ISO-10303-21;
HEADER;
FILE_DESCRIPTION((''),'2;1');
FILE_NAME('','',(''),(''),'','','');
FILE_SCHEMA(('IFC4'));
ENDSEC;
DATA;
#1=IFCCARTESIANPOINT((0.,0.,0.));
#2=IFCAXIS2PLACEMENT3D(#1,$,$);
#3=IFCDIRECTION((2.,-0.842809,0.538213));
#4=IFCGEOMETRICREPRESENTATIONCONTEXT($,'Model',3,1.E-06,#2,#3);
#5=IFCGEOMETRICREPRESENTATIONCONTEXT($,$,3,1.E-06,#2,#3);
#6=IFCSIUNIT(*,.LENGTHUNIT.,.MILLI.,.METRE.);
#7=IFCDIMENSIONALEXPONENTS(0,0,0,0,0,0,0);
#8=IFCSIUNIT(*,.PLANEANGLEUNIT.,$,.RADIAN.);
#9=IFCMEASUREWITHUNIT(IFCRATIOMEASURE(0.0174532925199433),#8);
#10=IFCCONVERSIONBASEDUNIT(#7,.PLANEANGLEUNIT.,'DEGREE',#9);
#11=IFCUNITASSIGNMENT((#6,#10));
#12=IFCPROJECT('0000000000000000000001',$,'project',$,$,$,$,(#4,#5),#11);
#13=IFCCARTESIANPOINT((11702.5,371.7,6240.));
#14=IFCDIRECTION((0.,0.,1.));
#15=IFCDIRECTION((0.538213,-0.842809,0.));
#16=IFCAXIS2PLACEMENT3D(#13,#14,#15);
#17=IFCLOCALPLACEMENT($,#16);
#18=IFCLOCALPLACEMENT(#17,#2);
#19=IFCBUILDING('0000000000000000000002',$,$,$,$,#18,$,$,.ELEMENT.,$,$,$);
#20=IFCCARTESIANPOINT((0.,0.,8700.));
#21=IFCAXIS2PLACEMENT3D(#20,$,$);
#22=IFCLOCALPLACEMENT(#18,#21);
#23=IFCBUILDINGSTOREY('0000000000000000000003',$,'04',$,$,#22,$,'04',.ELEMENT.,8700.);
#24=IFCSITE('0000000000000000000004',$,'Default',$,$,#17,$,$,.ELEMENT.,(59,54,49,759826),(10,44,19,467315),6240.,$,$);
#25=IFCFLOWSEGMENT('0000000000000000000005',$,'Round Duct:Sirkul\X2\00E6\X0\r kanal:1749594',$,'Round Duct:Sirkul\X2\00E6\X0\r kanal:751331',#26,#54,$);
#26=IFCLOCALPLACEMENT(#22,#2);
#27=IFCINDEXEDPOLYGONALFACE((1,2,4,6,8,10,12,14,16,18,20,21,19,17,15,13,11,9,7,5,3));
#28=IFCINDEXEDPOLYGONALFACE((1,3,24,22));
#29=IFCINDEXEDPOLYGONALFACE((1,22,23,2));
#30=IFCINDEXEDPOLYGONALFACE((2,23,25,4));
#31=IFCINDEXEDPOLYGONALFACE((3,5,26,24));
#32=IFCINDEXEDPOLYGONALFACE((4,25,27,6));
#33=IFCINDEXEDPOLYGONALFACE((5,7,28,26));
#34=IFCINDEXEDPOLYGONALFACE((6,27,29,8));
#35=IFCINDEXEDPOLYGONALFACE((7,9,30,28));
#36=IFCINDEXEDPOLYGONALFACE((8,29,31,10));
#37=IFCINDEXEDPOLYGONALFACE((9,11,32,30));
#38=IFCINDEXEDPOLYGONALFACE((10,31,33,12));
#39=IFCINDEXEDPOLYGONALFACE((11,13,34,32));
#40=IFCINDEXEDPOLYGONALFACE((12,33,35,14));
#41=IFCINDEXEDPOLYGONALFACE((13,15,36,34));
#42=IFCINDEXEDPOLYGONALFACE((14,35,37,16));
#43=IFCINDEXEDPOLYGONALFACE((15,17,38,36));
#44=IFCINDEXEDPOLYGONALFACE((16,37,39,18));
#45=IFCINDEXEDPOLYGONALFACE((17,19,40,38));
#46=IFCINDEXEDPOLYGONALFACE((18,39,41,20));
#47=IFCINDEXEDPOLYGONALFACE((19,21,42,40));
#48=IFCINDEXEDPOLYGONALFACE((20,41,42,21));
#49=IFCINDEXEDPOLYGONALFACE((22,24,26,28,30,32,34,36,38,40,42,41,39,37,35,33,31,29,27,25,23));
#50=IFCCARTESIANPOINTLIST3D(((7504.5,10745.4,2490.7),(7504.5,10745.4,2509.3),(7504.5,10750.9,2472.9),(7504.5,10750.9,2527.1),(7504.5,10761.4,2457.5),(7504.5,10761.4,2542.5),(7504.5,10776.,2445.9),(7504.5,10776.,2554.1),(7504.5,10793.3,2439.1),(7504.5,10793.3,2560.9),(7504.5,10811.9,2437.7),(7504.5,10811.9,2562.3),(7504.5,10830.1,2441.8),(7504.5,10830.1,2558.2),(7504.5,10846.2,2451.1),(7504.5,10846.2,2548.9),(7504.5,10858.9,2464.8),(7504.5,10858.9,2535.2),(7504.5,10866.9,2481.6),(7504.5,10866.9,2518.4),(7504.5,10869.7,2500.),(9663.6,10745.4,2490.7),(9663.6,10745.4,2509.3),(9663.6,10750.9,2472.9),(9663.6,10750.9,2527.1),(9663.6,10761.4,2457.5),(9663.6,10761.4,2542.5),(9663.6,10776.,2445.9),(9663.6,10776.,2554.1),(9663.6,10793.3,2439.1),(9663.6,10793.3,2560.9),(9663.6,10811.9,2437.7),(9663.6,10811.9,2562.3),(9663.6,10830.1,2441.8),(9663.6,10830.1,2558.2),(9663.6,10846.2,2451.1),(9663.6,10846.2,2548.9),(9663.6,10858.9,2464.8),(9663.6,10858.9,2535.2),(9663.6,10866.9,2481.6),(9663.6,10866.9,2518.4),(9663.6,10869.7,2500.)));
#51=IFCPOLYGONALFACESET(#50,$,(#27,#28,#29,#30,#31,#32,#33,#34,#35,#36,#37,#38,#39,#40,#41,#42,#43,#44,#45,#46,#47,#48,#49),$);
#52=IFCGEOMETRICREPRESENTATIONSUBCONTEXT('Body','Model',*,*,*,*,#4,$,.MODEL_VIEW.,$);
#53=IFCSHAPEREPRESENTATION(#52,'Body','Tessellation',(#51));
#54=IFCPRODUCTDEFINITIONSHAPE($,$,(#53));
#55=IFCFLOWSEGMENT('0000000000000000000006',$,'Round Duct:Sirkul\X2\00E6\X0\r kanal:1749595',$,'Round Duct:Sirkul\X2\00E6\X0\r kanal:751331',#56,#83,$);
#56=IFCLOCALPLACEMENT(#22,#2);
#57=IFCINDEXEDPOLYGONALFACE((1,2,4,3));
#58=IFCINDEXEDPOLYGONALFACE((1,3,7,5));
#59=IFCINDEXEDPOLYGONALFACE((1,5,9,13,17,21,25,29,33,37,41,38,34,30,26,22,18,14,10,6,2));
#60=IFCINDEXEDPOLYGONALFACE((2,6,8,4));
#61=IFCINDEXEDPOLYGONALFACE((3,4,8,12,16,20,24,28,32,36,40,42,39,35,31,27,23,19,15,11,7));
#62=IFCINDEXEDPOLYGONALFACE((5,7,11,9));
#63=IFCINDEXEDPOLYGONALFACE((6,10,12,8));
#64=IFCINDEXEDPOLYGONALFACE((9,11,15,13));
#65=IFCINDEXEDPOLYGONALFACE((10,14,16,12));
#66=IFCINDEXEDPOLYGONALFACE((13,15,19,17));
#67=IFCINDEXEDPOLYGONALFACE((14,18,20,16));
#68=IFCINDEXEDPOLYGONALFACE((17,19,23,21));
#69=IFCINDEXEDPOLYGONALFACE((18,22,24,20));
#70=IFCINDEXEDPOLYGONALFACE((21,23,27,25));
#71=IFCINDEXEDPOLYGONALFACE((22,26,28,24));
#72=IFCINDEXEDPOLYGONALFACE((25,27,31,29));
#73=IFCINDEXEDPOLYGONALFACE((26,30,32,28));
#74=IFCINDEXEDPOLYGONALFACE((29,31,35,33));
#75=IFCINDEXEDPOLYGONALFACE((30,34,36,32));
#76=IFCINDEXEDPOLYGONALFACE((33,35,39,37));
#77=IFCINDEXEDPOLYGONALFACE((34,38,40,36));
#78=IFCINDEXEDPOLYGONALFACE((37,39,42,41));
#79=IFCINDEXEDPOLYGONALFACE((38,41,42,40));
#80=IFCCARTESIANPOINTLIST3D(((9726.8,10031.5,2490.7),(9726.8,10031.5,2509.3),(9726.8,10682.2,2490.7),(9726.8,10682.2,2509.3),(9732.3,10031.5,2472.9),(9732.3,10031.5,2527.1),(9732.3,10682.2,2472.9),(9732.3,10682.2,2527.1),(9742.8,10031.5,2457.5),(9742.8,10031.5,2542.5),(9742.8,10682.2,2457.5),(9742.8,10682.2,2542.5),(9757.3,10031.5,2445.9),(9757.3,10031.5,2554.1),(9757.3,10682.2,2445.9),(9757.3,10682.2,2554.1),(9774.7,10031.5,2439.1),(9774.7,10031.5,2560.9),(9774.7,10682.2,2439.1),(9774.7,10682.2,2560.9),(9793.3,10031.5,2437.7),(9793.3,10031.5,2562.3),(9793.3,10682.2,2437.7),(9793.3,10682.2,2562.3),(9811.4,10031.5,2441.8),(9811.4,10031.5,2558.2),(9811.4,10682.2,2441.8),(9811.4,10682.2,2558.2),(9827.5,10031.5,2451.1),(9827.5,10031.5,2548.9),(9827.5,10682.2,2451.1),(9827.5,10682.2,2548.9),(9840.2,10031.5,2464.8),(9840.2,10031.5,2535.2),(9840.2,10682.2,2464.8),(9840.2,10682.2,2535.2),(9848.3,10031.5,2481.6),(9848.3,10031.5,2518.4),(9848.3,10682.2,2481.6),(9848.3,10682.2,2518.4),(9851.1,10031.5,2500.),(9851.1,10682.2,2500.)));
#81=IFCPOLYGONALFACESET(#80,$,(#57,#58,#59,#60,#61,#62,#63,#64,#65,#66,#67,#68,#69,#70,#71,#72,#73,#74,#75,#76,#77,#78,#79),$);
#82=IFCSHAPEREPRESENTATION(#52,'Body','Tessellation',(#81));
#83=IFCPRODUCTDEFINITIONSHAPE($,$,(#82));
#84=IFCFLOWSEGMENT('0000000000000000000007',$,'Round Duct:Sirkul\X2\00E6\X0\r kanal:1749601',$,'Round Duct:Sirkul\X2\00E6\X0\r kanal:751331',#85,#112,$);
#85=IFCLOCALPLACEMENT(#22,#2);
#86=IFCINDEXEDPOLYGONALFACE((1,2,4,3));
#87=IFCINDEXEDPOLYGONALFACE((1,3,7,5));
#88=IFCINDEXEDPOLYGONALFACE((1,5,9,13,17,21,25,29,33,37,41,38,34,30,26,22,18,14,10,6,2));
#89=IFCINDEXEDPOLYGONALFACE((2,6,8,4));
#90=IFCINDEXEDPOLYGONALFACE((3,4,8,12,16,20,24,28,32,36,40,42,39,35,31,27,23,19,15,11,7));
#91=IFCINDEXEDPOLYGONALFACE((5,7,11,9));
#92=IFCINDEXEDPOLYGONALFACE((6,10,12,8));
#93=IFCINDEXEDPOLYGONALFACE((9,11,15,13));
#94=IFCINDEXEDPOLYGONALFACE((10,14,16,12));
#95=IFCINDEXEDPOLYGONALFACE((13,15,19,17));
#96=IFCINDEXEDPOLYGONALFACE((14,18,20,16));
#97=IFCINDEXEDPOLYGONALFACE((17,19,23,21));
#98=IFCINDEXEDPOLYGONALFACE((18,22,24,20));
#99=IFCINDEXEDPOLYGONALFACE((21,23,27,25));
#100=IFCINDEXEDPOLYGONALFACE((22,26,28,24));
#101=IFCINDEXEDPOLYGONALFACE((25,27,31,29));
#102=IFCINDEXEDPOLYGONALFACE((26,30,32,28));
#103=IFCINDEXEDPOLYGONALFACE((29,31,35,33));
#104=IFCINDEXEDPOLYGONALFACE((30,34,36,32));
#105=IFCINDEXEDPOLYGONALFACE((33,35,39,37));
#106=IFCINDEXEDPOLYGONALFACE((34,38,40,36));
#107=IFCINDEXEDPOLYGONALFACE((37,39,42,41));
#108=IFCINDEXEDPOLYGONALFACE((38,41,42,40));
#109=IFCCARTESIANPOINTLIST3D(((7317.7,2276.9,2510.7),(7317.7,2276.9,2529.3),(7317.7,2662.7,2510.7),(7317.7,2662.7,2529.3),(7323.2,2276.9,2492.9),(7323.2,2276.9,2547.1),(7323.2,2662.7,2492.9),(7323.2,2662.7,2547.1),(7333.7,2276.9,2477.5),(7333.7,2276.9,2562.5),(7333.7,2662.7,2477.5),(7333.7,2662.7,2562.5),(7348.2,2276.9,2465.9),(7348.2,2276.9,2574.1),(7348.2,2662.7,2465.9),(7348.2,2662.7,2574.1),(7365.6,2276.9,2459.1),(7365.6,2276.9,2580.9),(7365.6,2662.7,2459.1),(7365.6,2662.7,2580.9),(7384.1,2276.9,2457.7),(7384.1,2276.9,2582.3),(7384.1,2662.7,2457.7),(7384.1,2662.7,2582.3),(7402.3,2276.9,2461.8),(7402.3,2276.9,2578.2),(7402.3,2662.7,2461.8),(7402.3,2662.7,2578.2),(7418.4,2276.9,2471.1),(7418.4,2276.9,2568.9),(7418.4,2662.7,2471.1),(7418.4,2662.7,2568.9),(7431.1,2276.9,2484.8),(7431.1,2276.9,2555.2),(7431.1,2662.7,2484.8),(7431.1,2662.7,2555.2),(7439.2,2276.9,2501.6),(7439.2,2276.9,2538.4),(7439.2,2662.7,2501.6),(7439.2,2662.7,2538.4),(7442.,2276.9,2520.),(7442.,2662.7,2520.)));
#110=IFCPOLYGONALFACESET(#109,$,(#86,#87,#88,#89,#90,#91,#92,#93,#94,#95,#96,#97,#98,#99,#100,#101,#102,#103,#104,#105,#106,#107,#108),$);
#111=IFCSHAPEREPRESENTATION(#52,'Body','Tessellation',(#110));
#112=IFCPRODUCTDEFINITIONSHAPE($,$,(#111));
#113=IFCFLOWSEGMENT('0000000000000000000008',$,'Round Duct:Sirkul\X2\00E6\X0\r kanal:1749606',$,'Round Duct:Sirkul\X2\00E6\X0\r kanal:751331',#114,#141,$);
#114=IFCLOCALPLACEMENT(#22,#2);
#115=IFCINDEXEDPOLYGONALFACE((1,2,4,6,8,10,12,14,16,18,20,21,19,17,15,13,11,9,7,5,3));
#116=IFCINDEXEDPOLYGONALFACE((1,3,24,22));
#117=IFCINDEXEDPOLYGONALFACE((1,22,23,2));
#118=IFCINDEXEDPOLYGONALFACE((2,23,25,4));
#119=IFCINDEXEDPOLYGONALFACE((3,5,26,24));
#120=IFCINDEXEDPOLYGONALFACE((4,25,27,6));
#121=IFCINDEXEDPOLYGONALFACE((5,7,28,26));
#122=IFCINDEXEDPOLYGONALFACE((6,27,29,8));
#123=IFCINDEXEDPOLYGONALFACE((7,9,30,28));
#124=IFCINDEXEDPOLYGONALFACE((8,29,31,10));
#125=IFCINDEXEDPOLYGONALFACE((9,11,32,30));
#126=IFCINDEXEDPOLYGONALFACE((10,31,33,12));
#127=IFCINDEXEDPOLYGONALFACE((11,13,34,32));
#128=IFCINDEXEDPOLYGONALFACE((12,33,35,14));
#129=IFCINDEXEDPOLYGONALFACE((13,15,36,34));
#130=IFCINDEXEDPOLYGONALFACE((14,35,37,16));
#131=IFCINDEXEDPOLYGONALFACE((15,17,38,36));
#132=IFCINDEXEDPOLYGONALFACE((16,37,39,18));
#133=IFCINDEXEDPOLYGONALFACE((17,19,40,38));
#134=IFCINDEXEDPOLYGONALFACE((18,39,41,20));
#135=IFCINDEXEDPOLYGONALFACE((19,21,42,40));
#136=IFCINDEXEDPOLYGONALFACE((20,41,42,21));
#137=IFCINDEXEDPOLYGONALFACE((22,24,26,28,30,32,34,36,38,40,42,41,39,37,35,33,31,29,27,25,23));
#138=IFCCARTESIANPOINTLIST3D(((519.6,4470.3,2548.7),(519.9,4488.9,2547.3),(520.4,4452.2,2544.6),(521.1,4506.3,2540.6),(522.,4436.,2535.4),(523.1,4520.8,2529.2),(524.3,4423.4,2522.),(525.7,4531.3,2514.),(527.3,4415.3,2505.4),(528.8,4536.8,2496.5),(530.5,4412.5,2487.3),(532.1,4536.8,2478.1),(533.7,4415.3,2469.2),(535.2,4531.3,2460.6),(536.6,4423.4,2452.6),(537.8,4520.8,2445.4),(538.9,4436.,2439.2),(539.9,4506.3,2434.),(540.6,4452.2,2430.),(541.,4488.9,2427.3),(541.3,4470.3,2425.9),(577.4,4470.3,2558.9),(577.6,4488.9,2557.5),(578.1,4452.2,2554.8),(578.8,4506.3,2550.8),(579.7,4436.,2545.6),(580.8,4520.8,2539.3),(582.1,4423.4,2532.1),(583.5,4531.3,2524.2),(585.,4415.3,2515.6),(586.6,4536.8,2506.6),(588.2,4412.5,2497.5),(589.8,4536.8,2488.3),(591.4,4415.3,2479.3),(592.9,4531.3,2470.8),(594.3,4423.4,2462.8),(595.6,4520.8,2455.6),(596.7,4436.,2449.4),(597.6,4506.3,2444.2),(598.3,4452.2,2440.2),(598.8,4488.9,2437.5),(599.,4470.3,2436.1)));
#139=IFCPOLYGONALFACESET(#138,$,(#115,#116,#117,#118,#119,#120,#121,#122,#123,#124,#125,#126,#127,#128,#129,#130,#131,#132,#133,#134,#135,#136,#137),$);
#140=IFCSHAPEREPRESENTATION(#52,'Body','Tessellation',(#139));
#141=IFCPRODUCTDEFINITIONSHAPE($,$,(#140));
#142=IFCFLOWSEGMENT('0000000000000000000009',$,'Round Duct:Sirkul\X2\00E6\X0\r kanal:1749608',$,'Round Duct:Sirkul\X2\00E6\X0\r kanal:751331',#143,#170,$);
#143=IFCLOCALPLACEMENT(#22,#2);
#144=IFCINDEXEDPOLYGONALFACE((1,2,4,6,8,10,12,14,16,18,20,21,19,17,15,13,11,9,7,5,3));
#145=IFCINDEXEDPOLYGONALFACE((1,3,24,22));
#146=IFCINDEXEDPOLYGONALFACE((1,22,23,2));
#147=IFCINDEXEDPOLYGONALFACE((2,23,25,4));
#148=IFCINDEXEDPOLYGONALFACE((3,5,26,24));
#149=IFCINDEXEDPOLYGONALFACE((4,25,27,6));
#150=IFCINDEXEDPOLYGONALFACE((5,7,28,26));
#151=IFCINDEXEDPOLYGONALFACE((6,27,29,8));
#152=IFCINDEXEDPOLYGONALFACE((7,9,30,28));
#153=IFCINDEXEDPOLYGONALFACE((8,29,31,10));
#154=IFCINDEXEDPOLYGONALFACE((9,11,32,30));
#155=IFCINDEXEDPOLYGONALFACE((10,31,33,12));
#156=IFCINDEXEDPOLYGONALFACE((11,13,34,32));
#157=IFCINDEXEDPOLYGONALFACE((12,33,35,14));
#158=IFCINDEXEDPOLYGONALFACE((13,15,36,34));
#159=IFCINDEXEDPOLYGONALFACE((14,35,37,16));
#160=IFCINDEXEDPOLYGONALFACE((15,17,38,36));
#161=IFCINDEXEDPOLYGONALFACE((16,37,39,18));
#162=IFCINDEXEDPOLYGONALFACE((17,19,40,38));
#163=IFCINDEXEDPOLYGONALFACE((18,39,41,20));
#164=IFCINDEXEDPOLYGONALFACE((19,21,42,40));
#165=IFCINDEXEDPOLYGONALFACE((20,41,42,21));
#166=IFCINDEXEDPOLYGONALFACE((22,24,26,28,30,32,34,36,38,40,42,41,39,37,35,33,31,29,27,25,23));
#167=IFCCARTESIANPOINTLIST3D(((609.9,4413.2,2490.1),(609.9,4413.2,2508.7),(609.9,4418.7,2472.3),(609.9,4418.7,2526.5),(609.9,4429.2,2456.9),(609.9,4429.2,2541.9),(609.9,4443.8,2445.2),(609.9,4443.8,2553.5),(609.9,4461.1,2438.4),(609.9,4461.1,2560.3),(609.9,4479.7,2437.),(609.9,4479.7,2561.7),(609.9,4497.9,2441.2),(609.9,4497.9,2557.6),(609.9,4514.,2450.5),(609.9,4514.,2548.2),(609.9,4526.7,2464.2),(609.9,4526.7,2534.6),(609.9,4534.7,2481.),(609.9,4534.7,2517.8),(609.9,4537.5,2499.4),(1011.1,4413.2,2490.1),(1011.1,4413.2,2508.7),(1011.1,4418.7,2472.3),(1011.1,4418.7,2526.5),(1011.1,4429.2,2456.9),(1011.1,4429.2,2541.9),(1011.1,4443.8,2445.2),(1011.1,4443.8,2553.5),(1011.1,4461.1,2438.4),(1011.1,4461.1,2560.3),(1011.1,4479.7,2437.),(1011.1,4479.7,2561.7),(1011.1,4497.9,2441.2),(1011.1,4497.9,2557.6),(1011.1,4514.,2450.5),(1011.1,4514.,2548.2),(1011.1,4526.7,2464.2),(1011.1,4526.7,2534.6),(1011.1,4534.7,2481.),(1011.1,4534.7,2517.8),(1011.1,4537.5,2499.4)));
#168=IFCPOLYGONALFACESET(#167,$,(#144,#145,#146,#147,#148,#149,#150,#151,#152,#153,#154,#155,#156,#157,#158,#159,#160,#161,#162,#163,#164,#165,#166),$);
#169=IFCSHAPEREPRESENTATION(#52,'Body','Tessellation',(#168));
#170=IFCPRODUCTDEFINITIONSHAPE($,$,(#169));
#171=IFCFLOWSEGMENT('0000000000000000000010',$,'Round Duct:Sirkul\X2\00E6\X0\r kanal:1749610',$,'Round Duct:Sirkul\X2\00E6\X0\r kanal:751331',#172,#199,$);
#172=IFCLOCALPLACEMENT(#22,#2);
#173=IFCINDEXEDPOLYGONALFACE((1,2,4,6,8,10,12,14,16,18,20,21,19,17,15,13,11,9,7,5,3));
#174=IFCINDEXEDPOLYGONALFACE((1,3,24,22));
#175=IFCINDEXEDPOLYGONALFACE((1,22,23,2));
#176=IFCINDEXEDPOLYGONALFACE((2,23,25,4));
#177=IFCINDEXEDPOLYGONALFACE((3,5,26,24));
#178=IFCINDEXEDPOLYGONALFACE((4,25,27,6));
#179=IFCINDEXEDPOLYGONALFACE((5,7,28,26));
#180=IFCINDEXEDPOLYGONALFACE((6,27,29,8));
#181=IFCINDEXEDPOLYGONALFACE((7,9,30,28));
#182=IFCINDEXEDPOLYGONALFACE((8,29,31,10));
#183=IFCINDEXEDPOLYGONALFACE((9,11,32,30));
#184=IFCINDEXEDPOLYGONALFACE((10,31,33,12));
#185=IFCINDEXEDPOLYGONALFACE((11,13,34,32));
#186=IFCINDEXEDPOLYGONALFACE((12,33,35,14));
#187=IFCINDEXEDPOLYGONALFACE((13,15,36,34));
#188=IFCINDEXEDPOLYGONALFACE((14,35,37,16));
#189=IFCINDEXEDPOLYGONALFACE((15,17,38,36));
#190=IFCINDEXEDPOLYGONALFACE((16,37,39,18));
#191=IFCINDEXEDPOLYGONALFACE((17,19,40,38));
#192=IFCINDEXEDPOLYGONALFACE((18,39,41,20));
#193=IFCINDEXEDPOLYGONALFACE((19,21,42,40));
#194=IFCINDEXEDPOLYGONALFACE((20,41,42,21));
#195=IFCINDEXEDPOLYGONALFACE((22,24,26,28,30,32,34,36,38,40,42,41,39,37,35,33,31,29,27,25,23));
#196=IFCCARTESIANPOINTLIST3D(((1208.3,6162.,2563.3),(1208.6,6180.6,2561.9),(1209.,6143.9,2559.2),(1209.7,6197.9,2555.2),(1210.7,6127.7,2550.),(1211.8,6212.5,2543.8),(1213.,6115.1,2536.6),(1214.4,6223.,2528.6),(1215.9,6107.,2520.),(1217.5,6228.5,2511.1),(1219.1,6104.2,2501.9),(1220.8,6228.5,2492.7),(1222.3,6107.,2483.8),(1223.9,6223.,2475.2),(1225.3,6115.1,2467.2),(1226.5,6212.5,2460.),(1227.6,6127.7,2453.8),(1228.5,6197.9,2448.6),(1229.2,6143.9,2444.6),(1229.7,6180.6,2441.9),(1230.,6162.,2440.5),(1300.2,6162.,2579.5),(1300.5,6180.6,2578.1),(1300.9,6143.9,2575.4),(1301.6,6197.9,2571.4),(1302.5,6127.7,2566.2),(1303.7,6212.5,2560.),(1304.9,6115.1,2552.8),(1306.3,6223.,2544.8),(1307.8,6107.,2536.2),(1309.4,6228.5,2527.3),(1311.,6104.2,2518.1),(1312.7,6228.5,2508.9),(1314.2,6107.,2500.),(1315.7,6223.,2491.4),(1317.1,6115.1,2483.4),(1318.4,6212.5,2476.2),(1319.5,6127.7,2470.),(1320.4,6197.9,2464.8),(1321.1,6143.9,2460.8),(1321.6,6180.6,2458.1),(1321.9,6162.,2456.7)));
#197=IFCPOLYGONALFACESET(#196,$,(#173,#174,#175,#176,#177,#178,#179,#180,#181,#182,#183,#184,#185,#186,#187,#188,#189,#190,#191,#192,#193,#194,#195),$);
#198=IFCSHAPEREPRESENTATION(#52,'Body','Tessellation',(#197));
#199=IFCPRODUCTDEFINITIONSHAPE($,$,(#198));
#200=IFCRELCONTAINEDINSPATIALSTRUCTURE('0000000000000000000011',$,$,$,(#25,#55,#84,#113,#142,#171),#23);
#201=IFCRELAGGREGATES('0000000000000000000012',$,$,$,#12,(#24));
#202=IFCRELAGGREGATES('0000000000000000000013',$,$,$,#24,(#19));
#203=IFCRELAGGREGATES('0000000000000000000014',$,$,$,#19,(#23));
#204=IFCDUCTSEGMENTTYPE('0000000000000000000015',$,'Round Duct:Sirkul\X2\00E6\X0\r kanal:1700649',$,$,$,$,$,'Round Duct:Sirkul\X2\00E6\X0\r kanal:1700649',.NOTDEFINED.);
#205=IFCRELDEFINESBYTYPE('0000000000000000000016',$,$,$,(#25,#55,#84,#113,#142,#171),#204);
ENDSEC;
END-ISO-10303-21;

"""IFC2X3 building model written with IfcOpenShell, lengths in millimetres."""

from ifc_helpers import new_model, entity, si_unit, converted_unit, direction, frame, frame_2d, origin, origin_2d_with_axis, place, context, subcontext, project, spatial, circle, extrude, type_object, element, save


model = new_model("IFC2X3")

# Units and contexts
model_context = context("Model", 3, precision=1e-06, world=origin(), true_north=direction((2.0, -0.842809, 0.538213)))
context_of_model = context(None, 3, precision=1e-06, world=origin(), true_north=direction((2.0, -0.842809, 0.538213)))
body_context = subcontext(model_context, "Body", "Model", "MODEL_VIEW")
ifc_project = project(units=[si_unit("LENGTHUNIT", "METRE", prefix="MILLI"), converted_unit("PLANEANGLEUNIT", "DEGREE", entity("IfcRatioMeasure", 0.0174532925199433), si_unit("PLANEANGLEUNIT", "RADIAN"), dimensions=[0, 0, 0, 0, 0, 0, 0])], contexts=[model_context, context_of_model])

# Site, building, storey
site_placement = place(None, frame((11702.5, 371.7, 6240.0), z_axis=(0.0, 0.0, 1.0), x_axis=(0.538213, -0.842809, 0.0)))
site = spatial("IfcSite", under=ifc_project, at=site_placement, Name="Default", CompositionType="ELEMENT", RefLatitude=(59, 54, 49, 759826), RefLongitude=(10, 44, 19, 467315), RefElevation=6240.0)
building_placement = place(site_placement, origin())
building = spatial("IfcBuilding", under=site, at=building_placement, CompositionType="ELEMENT")
storey_placement = place(building_placement, frame((0.0, 0.0, 8700.0)))
storey = spatial("IfcBuildingStorey", under=building, at=storey_placement, Name="04", LongName="04", CompositionType="ELEMENT", Elevation=8700.0)

# Flow segments
duct_segment_type_1 = type_object("IfcDuctSegmentType", Name="Round Duct:Sirkulær kanal:1700649", ElementType="Round Duct:Sirkulær kanal:1700649", PredefinedType="NOTDEFINED")
flow_segment_1_placement = place(storey_placement, origin())
element("IfcFlowSegment", 1, at=flow_segment_1_placement, inside=storey, type_object=duct_segment_type_1, Name="Round Duct:Sirkulær kanal:1749594", ObjectType="Round Duct:Sirkulær kanal:751331", context=body_context, shape_type="SweptSolid", body=[
    extrude(circle(Radius=62.5, at=origin_2d_with_axis()), frame((7504.5, 10807.2, 2500.0), z_axis=(1.0, 0.0, 0.0), x_axis=(0.0, 1.0, 0.0)), (0.0, 0.0, 1.0), 2159.1),
])
flow_segment_2_placement = place(storey_placement, origin())
element("IfcFlowSegment", 2, at=flow_segment_2_placement, inside=storey, type_object=duct_segment_type_1, Name="Round Duct:Sirkulær kanal:1749595", ObjectType="Round Duct:Sirkulær kanal:751331", context=body_context, shape_type="SweptSolid", body=[
    extrude(circle(Radius=62.5, at=origin_2d_with_axis()), frame((9788.6, 10031.5, 2500.0), z_axis=(0.0, 1.0, 0.0), x_axis=(1.0, 0.0, 0.0)), (0.0, 0.0, 1.0), 650.7),
])
flow_segment_3_placement = place(storey_placement, origin())
element("IfcFlowSegment", 3, at=flow_segment_3_placement, inside=storey, type_object=duct_segment_type_1, Name="Round Duct:Sirkulær kanal:1749601", ObjectType="Round Duct:Sirkulær kanal:751331", context=body_context, shape_type="SweptSolid", body=[
    extrude(circle(Radius=62.5, at=frame_2d((0.0, 0.0), x_axis=(1.0, 0.0))), frame((7379.5, 2276.9, 2520.0), z_axis=(0.0, 1.0, 0.0), x_axis=(1.0, 0.0, 0.0)), (0.0, 0.0, 1.0), 385.9),
])
flow_segment_4_placement = place(storey_placement, origin())
element("IfcFlowSegment", 4, at=flow_segment_4_placement, inside=storey, type_object=duct_segment_type_1, Name="Round Duct:Sirkulær kanal:1749606", ObjectType="Round Duct:Sirkulær kanal:751331", context=body_context, shape_type="SweptSolid", body=[
    extrude(circle(Radius=62.5, at=frame_2d((0.0, 0.0), x_axis=(1.0, 0.0))), frame((530.5, 4475.0, 2487.3), z_axis=(0.984808, 0.0, 0.173648), x_axis=(0.0, -1.0, 0.0)), (0.0, 0.0, 1.0), 58.6),
])
flow_segment_5_placement = place(storey_placement, origin())
element("IfcFlowSegment", 5, at=flow_segment_5_placement, inside=storey, type_object=duct_segment_type_1, Name="Round Duct:Sirkulær kanal:1749608", ObjectType="Round Duct:Sirkulær kanal:751331", context=body_context, shape_type="SweptSolid", body=[
    extrude(circle(Radius=62.5, at=frame_2d((0.0, 0.0), x_axis=(1.0, 0.0))), frame((609.9, 4475.0, 2499.4), z_axis=(1.0, 0.0, 0.0), x_axis=(0.0, 1.0, 0.0)), (0.0, 0.0, 1.0), 401.3),
])
flow_segment_6_placement = place(storey_placement, origin())
element("IfcFlowSegment", 6, at=flow_segment_6_placement, inside=storey, type_object=duct_segment_type_1, Name="Round Duct:Sirkulær kanal:1749610", ObjectType="Round Duct:Sirkulær kanal:751331", context=body_context, shape_type="SweptSolid", body=[
    extrude(circle(Radius=62.5, at=frame_2d((0.0, 0.0), x_axis=(1.0, 0.0))), frame((1219.1, 6166.7, 2501.9), z_axis=(0.984808, 0.0, 0.173648), x_axis=(0.0, -1.0, 0.0)), (0.0, 0.0, 1.0), 93.3),
])

save(model, "model.ifc")
